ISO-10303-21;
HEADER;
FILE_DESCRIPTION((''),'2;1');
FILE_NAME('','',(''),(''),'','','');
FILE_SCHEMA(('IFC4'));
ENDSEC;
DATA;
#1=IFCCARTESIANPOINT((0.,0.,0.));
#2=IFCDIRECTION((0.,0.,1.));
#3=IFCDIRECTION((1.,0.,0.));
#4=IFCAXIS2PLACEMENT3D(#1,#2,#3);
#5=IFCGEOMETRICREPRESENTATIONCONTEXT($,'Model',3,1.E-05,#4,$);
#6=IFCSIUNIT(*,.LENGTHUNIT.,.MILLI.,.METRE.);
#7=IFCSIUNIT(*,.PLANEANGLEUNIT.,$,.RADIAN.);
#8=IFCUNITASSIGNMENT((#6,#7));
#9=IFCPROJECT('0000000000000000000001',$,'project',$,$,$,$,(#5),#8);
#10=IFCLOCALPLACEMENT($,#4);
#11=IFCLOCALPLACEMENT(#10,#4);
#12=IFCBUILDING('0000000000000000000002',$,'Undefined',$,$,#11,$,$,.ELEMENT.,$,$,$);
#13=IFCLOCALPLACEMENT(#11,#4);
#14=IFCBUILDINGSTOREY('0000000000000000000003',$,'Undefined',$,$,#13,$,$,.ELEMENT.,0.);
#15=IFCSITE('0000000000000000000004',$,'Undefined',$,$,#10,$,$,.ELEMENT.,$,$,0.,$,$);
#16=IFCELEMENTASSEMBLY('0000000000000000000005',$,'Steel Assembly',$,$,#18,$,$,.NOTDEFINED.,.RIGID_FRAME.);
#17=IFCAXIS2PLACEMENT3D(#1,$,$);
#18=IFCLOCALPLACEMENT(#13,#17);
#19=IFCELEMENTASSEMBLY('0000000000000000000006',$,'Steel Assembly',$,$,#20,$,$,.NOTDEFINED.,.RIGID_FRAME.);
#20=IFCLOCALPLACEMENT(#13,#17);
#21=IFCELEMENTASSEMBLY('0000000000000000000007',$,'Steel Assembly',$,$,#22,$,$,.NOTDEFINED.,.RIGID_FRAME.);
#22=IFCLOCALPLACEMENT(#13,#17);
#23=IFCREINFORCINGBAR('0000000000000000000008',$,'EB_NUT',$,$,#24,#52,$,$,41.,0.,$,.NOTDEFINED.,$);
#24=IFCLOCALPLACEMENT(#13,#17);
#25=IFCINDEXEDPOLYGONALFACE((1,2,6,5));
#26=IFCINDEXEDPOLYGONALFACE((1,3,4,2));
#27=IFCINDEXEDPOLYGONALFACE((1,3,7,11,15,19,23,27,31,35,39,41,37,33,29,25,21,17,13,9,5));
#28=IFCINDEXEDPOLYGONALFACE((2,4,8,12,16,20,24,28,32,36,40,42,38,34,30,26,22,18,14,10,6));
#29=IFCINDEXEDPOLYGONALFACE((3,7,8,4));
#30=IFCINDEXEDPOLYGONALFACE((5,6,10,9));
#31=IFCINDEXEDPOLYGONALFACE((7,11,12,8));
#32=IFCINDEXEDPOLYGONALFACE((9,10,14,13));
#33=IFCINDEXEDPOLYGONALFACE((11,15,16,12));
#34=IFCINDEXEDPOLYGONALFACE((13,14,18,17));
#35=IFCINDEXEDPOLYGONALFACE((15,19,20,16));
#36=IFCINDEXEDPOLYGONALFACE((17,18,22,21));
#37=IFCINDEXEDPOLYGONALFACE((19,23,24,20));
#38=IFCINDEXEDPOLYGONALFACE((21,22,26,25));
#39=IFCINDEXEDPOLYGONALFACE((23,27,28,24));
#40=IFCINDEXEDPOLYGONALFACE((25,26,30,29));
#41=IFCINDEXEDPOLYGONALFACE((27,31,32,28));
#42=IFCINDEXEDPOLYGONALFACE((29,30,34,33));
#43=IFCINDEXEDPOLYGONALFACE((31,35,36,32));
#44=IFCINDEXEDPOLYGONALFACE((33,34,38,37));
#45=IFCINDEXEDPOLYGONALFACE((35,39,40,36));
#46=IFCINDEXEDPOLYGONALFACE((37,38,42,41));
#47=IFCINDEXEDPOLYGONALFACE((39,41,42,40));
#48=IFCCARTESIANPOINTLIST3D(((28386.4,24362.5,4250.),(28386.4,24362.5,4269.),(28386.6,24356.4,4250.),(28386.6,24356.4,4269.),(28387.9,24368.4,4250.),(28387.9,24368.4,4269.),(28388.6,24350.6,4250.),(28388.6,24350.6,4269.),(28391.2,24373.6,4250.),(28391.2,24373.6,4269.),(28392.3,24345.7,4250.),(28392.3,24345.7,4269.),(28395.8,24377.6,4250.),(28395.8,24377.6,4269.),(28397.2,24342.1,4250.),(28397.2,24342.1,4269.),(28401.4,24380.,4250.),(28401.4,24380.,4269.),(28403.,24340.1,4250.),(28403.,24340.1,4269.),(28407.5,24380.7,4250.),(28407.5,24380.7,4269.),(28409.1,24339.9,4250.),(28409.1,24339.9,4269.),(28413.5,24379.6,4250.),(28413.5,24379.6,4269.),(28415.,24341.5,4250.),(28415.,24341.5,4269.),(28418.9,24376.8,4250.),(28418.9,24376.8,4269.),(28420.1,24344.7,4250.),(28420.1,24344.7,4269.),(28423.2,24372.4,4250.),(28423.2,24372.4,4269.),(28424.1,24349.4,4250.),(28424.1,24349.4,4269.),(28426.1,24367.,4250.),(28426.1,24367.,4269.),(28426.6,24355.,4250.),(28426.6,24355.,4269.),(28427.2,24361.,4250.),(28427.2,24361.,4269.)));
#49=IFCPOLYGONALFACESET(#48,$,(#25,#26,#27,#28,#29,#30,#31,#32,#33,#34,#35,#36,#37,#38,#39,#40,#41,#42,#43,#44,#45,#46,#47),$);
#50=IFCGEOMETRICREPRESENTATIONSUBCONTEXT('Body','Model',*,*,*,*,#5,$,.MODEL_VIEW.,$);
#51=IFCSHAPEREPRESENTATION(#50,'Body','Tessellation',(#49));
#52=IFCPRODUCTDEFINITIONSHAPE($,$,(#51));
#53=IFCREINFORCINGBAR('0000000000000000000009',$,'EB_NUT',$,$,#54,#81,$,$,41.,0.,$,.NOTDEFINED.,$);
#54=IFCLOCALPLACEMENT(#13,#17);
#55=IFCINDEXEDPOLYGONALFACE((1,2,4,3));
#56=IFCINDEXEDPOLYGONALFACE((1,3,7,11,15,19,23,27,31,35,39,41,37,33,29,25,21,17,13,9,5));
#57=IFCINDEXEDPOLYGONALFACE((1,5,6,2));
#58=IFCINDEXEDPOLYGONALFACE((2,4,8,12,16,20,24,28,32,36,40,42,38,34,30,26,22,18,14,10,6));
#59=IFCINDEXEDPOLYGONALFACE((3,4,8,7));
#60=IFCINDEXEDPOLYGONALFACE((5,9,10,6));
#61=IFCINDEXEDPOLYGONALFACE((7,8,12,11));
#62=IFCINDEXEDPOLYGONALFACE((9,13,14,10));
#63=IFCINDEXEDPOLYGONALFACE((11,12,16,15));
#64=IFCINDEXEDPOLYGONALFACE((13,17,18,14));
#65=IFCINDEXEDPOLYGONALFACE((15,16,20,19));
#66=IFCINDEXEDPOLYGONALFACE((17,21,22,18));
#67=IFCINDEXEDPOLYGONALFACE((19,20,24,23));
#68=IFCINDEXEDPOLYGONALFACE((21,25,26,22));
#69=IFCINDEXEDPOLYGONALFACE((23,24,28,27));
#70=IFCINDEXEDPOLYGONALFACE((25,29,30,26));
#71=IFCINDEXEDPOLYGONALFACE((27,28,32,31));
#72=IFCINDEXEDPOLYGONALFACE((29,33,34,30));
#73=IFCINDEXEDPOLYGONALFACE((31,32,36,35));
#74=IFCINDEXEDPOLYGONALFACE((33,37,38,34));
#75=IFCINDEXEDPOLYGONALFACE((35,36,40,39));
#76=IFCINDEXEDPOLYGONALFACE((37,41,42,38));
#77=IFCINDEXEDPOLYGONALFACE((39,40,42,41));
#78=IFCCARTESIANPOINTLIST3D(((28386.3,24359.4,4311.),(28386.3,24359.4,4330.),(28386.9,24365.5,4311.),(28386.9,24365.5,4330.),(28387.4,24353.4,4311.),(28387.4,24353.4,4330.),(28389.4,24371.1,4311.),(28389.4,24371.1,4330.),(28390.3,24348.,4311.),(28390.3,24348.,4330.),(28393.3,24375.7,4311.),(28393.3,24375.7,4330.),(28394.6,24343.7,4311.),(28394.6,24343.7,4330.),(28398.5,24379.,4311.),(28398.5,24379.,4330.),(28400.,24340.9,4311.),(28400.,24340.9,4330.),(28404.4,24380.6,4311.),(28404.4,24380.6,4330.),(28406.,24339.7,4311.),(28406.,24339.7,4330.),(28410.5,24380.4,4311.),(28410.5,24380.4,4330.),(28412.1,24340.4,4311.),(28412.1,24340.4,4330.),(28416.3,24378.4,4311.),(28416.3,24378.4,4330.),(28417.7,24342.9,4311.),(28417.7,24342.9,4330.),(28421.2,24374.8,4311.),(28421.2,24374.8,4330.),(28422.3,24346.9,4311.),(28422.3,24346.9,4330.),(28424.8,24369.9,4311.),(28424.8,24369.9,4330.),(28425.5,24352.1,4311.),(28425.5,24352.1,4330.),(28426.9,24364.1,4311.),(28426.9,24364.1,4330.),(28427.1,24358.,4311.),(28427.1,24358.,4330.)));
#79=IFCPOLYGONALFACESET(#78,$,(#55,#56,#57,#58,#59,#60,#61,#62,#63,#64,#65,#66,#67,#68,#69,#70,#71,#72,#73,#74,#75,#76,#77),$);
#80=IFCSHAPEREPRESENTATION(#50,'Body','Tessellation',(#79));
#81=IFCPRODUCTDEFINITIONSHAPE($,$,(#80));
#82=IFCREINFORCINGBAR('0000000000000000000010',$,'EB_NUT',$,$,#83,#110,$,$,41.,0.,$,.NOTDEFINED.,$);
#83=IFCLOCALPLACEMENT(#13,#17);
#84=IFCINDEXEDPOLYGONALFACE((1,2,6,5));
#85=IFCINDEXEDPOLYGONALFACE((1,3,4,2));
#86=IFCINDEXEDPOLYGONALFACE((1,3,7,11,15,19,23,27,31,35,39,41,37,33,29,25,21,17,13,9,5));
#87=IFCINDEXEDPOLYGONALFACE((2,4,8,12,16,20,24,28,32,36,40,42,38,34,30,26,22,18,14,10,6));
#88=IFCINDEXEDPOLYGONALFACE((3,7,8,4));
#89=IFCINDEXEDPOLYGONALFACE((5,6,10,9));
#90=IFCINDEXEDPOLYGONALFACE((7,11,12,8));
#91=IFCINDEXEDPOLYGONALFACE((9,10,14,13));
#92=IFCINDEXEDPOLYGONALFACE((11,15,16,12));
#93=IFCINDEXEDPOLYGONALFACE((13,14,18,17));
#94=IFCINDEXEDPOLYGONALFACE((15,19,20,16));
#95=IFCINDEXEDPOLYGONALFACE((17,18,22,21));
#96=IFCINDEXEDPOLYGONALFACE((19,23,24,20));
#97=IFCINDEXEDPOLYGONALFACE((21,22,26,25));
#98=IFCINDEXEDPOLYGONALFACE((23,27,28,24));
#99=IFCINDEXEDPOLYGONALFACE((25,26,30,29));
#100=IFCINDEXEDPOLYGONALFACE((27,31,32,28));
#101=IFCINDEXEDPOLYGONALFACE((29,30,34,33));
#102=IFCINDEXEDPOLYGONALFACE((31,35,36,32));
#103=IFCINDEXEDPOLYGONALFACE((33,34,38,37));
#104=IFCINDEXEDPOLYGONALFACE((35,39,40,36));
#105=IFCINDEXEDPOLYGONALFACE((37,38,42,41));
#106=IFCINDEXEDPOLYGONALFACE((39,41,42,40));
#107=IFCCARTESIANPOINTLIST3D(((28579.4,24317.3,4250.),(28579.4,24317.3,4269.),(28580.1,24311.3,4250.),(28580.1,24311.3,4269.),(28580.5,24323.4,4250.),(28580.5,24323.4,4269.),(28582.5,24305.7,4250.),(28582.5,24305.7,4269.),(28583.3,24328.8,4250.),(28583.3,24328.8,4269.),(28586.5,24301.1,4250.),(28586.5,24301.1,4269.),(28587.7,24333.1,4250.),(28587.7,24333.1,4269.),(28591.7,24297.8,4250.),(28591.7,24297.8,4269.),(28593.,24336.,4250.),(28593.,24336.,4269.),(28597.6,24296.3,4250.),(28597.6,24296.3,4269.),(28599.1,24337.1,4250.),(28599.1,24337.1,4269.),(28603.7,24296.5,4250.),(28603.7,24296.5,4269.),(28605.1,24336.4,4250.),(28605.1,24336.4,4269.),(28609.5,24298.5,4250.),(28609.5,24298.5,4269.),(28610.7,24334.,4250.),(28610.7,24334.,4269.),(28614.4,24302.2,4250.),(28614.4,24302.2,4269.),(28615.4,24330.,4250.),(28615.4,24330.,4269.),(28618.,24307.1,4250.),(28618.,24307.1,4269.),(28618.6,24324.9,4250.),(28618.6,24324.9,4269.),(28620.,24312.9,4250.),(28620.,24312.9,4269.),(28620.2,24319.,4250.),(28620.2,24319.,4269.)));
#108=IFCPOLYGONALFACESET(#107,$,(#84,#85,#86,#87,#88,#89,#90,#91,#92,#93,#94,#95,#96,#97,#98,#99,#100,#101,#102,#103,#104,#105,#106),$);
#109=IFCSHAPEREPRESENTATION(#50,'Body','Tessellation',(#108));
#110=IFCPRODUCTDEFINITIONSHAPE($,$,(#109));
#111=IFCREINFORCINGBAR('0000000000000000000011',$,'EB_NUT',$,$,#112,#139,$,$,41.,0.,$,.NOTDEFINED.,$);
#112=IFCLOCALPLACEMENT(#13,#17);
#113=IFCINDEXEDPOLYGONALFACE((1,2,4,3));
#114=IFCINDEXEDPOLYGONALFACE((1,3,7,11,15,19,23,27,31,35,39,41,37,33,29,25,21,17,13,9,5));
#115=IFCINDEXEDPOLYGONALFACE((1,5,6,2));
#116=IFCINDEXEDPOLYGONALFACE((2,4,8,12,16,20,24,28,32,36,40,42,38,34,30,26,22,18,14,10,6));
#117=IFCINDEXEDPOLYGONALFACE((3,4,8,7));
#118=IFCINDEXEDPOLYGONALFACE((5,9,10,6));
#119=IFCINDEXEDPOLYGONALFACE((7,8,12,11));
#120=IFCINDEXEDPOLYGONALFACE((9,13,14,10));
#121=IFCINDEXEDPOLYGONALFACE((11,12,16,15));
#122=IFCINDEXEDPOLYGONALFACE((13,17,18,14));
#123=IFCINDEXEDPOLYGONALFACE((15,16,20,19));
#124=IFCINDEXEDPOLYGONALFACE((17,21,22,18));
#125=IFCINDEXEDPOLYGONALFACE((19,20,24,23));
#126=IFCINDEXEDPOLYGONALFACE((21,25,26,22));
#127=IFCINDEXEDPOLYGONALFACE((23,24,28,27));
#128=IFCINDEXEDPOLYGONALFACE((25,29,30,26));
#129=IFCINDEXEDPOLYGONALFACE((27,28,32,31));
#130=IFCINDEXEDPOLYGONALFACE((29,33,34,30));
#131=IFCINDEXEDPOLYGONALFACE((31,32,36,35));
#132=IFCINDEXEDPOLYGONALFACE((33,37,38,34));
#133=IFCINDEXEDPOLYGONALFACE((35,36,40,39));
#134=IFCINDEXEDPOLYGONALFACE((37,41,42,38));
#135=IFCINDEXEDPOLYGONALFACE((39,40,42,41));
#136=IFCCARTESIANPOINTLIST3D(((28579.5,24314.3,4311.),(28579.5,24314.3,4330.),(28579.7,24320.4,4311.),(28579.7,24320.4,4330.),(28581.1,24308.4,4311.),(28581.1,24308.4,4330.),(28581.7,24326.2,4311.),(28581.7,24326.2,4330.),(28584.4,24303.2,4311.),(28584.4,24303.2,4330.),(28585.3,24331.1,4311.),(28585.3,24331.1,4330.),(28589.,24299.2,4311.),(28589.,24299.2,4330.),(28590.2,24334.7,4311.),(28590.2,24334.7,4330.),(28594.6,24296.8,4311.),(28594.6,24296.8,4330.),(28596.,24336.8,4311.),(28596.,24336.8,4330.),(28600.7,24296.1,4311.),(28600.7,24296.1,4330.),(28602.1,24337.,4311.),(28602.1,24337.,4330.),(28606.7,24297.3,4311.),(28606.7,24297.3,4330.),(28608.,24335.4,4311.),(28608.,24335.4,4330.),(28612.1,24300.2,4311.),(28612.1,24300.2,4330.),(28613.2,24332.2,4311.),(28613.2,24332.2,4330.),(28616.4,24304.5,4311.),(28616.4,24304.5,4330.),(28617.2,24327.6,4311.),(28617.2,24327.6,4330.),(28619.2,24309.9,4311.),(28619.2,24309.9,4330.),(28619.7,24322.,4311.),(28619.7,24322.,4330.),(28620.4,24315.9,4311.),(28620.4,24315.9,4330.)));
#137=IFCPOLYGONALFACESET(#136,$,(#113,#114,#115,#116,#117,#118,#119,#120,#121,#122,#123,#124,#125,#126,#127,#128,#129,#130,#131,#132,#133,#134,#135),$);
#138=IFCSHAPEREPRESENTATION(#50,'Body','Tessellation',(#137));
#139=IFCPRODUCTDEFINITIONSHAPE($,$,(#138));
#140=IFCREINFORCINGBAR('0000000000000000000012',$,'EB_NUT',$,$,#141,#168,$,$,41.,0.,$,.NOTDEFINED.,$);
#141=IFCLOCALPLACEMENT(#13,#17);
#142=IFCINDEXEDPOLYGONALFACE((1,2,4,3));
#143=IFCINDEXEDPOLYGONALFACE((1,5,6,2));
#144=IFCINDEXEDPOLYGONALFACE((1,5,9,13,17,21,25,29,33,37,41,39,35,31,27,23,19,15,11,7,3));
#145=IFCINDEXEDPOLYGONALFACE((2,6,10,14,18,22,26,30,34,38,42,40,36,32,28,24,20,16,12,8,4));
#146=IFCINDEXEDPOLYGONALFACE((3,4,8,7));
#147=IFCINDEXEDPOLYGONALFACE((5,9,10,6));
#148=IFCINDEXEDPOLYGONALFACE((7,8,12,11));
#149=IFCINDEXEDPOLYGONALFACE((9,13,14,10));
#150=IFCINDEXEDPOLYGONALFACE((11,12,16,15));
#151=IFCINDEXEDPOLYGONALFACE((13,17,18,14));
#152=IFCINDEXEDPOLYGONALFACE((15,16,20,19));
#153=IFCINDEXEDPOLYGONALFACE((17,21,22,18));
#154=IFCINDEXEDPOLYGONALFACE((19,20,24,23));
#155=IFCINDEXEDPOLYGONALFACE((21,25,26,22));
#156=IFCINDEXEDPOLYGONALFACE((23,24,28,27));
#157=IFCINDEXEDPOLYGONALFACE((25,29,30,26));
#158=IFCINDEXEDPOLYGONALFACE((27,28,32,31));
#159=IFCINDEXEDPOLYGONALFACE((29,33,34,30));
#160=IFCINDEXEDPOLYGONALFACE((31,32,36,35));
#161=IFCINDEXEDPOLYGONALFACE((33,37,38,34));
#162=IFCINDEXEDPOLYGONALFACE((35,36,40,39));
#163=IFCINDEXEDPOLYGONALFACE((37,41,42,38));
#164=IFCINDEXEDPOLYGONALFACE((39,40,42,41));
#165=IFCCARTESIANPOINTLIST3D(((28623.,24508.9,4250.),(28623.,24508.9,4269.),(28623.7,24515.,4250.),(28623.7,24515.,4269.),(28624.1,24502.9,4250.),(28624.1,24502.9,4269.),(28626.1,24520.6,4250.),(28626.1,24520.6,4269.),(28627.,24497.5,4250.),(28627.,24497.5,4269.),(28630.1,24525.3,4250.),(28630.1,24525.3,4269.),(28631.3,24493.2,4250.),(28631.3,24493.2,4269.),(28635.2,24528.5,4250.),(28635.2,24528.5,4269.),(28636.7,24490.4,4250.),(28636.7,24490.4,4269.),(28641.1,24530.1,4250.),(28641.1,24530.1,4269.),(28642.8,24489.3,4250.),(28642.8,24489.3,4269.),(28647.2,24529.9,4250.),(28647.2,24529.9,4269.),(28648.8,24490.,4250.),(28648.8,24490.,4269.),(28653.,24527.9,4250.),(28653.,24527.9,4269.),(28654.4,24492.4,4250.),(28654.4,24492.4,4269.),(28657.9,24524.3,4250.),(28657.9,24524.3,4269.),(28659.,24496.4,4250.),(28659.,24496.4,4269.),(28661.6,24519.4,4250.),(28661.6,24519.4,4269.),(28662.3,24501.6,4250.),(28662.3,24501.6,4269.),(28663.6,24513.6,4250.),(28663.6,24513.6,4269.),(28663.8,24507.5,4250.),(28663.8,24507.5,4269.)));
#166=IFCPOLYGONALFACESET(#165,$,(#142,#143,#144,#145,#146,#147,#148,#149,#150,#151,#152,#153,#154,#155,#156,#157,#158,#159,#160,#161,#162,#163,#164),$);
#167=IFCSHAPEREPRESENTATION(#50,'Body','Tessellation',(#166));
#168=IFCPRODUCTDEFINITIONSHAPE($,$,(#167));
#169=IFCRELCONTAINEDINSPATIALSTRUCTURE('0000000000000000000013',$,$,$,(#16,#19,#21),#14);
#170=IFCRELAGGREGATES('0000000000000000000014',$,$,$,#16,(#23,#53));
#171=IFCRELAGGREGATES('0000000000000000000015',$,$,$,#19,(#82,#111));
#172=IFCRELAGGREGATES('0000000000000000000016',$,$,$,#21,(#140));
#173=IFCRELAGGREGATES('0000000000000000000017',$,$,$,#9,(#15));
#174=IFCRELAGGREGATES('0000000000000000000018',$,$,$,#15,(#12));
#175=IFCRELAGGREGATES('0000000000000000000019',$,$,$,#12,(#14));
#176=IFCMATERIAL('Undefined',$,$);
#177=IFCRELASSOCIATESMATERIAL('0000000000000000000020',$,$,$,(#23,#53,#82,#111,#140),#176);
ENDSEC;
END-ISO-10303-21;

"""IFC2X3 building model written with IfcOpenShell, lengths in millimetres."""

from ifc_helpers import new_model, entity, si_unit, frame, origin_with_axes, place, context, subcontext, project, spatial, source, transform, mapped, material, element, aggregate, save


model = new_model("IFC2X3")

# Units and contexts
model_context = context("Model", 3, precision=1e-05, world=origin_with_axes())
body_context = subcontext(model_context, "Body", "Model", "MODEL_VIEW")
ifc_project = project(units=[si_unit("LENGTHUNIT", "METRE", prefix="MILLI"), si_unit("PLANEANGLEUNIT", "RADIAN")], contexts=[model_context])

# Site, building, storey
site_placement = place(None, origin_with_axes())
site = spatial("IfcSite", under=ifc_project, at=site_placement, Name="Undefined", CompositionType="ELEMENT", RefElevation=0.0)
building_placement = place(site_placement, origin_with_axes())
building = spatial("IfcBuilding", under=site, at=building_placement, Name="Undefined", CompositionType="ELEMENT")
storey_placement = place(building_placement, origin_with_axes())
storey = spatial("IfcBuildingStorey", under=building, at=storey_placement, Name="Undefined", CompositionType="ELEMENT", Elevation=0.0)

# Element assemblies
assembly_1_placement = place(storey_placement, origin_with_axes())
assembly_1 = element("IfcElementAssembly", 1, at=assembly_1_placement, inside=storey, Name="Steel Assembly", AssemblyPlace="NOTDEFINED", PredefinedType="RIGID_FRAME")
assembly_2_placement = place(storey_placement, origin_with_axes())
assembly_2 = element("IfcElementAssembly", 2, at=assembly_2_placement, inside=storey, Name="Steel Assembly", AssemblyPlace="NOTDEFINED", PredefinedType="RIGID_FRAME")
assembly_3_placement = place(storey_placement, origin_with_axes())
assembly_3 = element("IfcElementAssembly", 3, at=assembly_3_placement, inside=storey, Name="Steel Assembly", AssemblyPlace="NOTDEFINED", PredefinedType="RIGID_FRAME")

# Shared definitions
ifc_material_1 = material(Name="Undefined")

# Reinforcing bars
shared_shape_1 = source(origin_with_axes(), body_context, "Body", "AdvancedSweptSolid", [
    entity("IfcSweptDiskSolid", entity("IfcTrimmedCurve", entity("IfcLine", entity("IfcCartesianPoint", [0.0, 0.0, 0.0]), entity("IfcVector", entity("IfcDirection", [1.0, 0.0, 0.0]), 1.0)), [entity("IfcParameterValue", 0.0)], [entity("IfcParameterValue", 19.0)], True, "PARAMETER"), 20.5, None, 0.0, 19.0),
])
reinforcing_bar_1_placement = place(assembly_1_placement, frame((28406.7, 24360.2, 4250.0), z_axis=(-0.534023, 0.84547, 0.0), x_axis=(0.0, 0.0, 1.0)))
reinforcing_bar_1 = element("IfcReinforcingBar", 4, at=reinforcing_bar_1_placement, material=ifc_material_1, Name="EB_NUT", BarRole="NOTDEFINED", CrossSectionArea=0.0, NominalDiameter=41.0, context=body_context, shape_type="MappedRepresentation", body=[
    mapped(shared_shape_1, transform((0.0, 0.0, 0.0))),
])
shared_shape_2 = source(origin_with_axes(), body_context, "Body", "AdvancedSweptSolid", [
    entity("IfcSweptDiskSolid", entity("IfcTrimmedCurve", entity("IfcLine", entity("IfcCartesianPoint", [0.0, 0.0, 0.0]), entity("IfcVector", entity("IfcDirection", [1.0, 0.0, 0.0]), 1.0)), [entity("IfcParameterValue", 0.0)], [entity("IfcParameterValue", 19.0)], True, "PARAMETER"), 20.5, None, 0.0, 19.0),
])
reinforcing_bar_2_placement = place(assembly_1_placement, frame((28406.7, 24360.2, 4330.0), z_axis=(0.534023, -0.84547, 0.0), x_axis=(0.0, 0.0, -1.0)))
reinforcing_bar_2 = element("IfcReinforcingBar", 5, at=reinforcing_bar_2_placement, material=ifc_material_1, Name="EB_NUT", BarRole="NOTDEFINED", CrossSectionArea=0.0, NominalDiameter=41.0, context=body_context, shape_type="MappedRepresentation", body=[
    mapped(shared_shape_2, transform((0.0, 0.0, 0.0))),
])
aggregate(assembly_1, [reinforcing_bar_1, reinforcing_bar_2])
shared_shape_3 = source(origin_with_axes(), body_context, "Body", "AdvancedSweptSolid", [
    entity("IfcSweptDiskSolid", entity("IfcTrimmedCurve", entity("IfcLine", entity("IfcCartesianPoint", [0.0, 0.0, 0.0]), entity("IfcVector", entity("IfcDirection", [1.0, 0.0, 0.0]), 1.0)), [entity("IfcParameterValue", 0.0)], [entity("IfcParameterValue", 19.0)], True, "PARAMETER"), 20.5, None, 0.0, 19.0),
])
reinforcing_bar_3_placement = place(assembly_2_placement, frame((28599.9, 24316.6, 4250.0), z_axis=(-0.84547, -0.534023, 0.0), x_axis=(0.0, 0.0, 1.0)))
reinforcing_bar_3 = element("IfcReinforcingBar", 6, at=reinforcing_bar_3_placement, material=ifc_material_1, Name="EB_NUT", BarRole="NOTDEFINED", CrossSectionArea=0.0, NominalDiameter=41.0, context=body_context, shape_type="MappedRepresentation", body=[
    mapped(shared_shape_3, transform((0.0, 0.0, 0.0))),
])
shared_shape_4 = source(origin_with_axes(), body_context, "Body", "AdvancedSweptSolid", [
    entity("IfcSweptDiskSolid", entity("IfcTrimmedCurve", entity("IfcLine", entity("IfcCartesianPoint", [0.0, 0.0, 0.0]), entity("IfcVector", entity("IfcDirection", [1.0, 0.0, 0.0]), 1.0)), [entity("IfcParameterValue", 0.0)], [entity("IfcParameterValue", 19.0)], True, "PARAMETER"), 20.5, None, 0.0, 19.0),
])
reinforcing_bar_4_placement = place(assembly_2_placement, frame((28599.9, 24316.6, 4330.0), z_axis=(0.84547, 0.534023, 0.0), x_axis=(0.0, 0.0, -1.0)))
reinforcing_bar_4 = element("IfcReinforcingBar", 7, at=reinforcing_bar_4_placement, material=ifc_material_1, Name="EB_NUT", BarRole="NOTDEFINED", CrossSectionArea=0.0, NominalDiameter=41.0, context=body_context, shape_type="MappedRepresentation", body=[
    mapped(shared_shape_4, transform((0.0, 0.0, 0.0))),
])
aggregate(assembly_2, [reinforcing_bar_3, reinforcing_bar_4])
shared_shape_5 = source(origin_with_axes(), body_context, "Body", "AdvancedSweptSolid", [
    entity("IfcSweptDiskSolid", entity("IfcTrimmedCurve", entity("IfcLine", entity("IfcCartesianPoint", [0.0, 0.0, 0.0]), entity("IfcVector", entity("IfcDirection", [1.0, 0.0, 0.0]), 1.0)), [entity("IfcParameterValue", 0.0)], [entity("IfcParameterValue", 19.0)], True, "PARAMETER"), 20.5, None, 0.0, 19.0),
])
reinforcing_bar_5_placement = place(assembly_3_placement, frame((28643.5, 24509.8, 4250.0), z_axis=(0.534023, -0.84547, 0.0), x_axis=(0.0, 0.0, 1.0)))
reinforcing_bar_5 = element("IfcReinforcingBar", 8, at=reinforcing_bar_5_placement, material=ifc_material_1, Name="EB_NUT", BarRole="NOTDEFINED", CrossSectionArea=0.0, NominalDiameter=41.0, context=body_context, shape_type="MappedRepresentation", body=[
    mapped(shared_shape_5, transform((0.0, 0.0, 0.0))),
])
aggregate(assembly_3, [reinforcing_bar_5])

save(model, "model.ifc")
